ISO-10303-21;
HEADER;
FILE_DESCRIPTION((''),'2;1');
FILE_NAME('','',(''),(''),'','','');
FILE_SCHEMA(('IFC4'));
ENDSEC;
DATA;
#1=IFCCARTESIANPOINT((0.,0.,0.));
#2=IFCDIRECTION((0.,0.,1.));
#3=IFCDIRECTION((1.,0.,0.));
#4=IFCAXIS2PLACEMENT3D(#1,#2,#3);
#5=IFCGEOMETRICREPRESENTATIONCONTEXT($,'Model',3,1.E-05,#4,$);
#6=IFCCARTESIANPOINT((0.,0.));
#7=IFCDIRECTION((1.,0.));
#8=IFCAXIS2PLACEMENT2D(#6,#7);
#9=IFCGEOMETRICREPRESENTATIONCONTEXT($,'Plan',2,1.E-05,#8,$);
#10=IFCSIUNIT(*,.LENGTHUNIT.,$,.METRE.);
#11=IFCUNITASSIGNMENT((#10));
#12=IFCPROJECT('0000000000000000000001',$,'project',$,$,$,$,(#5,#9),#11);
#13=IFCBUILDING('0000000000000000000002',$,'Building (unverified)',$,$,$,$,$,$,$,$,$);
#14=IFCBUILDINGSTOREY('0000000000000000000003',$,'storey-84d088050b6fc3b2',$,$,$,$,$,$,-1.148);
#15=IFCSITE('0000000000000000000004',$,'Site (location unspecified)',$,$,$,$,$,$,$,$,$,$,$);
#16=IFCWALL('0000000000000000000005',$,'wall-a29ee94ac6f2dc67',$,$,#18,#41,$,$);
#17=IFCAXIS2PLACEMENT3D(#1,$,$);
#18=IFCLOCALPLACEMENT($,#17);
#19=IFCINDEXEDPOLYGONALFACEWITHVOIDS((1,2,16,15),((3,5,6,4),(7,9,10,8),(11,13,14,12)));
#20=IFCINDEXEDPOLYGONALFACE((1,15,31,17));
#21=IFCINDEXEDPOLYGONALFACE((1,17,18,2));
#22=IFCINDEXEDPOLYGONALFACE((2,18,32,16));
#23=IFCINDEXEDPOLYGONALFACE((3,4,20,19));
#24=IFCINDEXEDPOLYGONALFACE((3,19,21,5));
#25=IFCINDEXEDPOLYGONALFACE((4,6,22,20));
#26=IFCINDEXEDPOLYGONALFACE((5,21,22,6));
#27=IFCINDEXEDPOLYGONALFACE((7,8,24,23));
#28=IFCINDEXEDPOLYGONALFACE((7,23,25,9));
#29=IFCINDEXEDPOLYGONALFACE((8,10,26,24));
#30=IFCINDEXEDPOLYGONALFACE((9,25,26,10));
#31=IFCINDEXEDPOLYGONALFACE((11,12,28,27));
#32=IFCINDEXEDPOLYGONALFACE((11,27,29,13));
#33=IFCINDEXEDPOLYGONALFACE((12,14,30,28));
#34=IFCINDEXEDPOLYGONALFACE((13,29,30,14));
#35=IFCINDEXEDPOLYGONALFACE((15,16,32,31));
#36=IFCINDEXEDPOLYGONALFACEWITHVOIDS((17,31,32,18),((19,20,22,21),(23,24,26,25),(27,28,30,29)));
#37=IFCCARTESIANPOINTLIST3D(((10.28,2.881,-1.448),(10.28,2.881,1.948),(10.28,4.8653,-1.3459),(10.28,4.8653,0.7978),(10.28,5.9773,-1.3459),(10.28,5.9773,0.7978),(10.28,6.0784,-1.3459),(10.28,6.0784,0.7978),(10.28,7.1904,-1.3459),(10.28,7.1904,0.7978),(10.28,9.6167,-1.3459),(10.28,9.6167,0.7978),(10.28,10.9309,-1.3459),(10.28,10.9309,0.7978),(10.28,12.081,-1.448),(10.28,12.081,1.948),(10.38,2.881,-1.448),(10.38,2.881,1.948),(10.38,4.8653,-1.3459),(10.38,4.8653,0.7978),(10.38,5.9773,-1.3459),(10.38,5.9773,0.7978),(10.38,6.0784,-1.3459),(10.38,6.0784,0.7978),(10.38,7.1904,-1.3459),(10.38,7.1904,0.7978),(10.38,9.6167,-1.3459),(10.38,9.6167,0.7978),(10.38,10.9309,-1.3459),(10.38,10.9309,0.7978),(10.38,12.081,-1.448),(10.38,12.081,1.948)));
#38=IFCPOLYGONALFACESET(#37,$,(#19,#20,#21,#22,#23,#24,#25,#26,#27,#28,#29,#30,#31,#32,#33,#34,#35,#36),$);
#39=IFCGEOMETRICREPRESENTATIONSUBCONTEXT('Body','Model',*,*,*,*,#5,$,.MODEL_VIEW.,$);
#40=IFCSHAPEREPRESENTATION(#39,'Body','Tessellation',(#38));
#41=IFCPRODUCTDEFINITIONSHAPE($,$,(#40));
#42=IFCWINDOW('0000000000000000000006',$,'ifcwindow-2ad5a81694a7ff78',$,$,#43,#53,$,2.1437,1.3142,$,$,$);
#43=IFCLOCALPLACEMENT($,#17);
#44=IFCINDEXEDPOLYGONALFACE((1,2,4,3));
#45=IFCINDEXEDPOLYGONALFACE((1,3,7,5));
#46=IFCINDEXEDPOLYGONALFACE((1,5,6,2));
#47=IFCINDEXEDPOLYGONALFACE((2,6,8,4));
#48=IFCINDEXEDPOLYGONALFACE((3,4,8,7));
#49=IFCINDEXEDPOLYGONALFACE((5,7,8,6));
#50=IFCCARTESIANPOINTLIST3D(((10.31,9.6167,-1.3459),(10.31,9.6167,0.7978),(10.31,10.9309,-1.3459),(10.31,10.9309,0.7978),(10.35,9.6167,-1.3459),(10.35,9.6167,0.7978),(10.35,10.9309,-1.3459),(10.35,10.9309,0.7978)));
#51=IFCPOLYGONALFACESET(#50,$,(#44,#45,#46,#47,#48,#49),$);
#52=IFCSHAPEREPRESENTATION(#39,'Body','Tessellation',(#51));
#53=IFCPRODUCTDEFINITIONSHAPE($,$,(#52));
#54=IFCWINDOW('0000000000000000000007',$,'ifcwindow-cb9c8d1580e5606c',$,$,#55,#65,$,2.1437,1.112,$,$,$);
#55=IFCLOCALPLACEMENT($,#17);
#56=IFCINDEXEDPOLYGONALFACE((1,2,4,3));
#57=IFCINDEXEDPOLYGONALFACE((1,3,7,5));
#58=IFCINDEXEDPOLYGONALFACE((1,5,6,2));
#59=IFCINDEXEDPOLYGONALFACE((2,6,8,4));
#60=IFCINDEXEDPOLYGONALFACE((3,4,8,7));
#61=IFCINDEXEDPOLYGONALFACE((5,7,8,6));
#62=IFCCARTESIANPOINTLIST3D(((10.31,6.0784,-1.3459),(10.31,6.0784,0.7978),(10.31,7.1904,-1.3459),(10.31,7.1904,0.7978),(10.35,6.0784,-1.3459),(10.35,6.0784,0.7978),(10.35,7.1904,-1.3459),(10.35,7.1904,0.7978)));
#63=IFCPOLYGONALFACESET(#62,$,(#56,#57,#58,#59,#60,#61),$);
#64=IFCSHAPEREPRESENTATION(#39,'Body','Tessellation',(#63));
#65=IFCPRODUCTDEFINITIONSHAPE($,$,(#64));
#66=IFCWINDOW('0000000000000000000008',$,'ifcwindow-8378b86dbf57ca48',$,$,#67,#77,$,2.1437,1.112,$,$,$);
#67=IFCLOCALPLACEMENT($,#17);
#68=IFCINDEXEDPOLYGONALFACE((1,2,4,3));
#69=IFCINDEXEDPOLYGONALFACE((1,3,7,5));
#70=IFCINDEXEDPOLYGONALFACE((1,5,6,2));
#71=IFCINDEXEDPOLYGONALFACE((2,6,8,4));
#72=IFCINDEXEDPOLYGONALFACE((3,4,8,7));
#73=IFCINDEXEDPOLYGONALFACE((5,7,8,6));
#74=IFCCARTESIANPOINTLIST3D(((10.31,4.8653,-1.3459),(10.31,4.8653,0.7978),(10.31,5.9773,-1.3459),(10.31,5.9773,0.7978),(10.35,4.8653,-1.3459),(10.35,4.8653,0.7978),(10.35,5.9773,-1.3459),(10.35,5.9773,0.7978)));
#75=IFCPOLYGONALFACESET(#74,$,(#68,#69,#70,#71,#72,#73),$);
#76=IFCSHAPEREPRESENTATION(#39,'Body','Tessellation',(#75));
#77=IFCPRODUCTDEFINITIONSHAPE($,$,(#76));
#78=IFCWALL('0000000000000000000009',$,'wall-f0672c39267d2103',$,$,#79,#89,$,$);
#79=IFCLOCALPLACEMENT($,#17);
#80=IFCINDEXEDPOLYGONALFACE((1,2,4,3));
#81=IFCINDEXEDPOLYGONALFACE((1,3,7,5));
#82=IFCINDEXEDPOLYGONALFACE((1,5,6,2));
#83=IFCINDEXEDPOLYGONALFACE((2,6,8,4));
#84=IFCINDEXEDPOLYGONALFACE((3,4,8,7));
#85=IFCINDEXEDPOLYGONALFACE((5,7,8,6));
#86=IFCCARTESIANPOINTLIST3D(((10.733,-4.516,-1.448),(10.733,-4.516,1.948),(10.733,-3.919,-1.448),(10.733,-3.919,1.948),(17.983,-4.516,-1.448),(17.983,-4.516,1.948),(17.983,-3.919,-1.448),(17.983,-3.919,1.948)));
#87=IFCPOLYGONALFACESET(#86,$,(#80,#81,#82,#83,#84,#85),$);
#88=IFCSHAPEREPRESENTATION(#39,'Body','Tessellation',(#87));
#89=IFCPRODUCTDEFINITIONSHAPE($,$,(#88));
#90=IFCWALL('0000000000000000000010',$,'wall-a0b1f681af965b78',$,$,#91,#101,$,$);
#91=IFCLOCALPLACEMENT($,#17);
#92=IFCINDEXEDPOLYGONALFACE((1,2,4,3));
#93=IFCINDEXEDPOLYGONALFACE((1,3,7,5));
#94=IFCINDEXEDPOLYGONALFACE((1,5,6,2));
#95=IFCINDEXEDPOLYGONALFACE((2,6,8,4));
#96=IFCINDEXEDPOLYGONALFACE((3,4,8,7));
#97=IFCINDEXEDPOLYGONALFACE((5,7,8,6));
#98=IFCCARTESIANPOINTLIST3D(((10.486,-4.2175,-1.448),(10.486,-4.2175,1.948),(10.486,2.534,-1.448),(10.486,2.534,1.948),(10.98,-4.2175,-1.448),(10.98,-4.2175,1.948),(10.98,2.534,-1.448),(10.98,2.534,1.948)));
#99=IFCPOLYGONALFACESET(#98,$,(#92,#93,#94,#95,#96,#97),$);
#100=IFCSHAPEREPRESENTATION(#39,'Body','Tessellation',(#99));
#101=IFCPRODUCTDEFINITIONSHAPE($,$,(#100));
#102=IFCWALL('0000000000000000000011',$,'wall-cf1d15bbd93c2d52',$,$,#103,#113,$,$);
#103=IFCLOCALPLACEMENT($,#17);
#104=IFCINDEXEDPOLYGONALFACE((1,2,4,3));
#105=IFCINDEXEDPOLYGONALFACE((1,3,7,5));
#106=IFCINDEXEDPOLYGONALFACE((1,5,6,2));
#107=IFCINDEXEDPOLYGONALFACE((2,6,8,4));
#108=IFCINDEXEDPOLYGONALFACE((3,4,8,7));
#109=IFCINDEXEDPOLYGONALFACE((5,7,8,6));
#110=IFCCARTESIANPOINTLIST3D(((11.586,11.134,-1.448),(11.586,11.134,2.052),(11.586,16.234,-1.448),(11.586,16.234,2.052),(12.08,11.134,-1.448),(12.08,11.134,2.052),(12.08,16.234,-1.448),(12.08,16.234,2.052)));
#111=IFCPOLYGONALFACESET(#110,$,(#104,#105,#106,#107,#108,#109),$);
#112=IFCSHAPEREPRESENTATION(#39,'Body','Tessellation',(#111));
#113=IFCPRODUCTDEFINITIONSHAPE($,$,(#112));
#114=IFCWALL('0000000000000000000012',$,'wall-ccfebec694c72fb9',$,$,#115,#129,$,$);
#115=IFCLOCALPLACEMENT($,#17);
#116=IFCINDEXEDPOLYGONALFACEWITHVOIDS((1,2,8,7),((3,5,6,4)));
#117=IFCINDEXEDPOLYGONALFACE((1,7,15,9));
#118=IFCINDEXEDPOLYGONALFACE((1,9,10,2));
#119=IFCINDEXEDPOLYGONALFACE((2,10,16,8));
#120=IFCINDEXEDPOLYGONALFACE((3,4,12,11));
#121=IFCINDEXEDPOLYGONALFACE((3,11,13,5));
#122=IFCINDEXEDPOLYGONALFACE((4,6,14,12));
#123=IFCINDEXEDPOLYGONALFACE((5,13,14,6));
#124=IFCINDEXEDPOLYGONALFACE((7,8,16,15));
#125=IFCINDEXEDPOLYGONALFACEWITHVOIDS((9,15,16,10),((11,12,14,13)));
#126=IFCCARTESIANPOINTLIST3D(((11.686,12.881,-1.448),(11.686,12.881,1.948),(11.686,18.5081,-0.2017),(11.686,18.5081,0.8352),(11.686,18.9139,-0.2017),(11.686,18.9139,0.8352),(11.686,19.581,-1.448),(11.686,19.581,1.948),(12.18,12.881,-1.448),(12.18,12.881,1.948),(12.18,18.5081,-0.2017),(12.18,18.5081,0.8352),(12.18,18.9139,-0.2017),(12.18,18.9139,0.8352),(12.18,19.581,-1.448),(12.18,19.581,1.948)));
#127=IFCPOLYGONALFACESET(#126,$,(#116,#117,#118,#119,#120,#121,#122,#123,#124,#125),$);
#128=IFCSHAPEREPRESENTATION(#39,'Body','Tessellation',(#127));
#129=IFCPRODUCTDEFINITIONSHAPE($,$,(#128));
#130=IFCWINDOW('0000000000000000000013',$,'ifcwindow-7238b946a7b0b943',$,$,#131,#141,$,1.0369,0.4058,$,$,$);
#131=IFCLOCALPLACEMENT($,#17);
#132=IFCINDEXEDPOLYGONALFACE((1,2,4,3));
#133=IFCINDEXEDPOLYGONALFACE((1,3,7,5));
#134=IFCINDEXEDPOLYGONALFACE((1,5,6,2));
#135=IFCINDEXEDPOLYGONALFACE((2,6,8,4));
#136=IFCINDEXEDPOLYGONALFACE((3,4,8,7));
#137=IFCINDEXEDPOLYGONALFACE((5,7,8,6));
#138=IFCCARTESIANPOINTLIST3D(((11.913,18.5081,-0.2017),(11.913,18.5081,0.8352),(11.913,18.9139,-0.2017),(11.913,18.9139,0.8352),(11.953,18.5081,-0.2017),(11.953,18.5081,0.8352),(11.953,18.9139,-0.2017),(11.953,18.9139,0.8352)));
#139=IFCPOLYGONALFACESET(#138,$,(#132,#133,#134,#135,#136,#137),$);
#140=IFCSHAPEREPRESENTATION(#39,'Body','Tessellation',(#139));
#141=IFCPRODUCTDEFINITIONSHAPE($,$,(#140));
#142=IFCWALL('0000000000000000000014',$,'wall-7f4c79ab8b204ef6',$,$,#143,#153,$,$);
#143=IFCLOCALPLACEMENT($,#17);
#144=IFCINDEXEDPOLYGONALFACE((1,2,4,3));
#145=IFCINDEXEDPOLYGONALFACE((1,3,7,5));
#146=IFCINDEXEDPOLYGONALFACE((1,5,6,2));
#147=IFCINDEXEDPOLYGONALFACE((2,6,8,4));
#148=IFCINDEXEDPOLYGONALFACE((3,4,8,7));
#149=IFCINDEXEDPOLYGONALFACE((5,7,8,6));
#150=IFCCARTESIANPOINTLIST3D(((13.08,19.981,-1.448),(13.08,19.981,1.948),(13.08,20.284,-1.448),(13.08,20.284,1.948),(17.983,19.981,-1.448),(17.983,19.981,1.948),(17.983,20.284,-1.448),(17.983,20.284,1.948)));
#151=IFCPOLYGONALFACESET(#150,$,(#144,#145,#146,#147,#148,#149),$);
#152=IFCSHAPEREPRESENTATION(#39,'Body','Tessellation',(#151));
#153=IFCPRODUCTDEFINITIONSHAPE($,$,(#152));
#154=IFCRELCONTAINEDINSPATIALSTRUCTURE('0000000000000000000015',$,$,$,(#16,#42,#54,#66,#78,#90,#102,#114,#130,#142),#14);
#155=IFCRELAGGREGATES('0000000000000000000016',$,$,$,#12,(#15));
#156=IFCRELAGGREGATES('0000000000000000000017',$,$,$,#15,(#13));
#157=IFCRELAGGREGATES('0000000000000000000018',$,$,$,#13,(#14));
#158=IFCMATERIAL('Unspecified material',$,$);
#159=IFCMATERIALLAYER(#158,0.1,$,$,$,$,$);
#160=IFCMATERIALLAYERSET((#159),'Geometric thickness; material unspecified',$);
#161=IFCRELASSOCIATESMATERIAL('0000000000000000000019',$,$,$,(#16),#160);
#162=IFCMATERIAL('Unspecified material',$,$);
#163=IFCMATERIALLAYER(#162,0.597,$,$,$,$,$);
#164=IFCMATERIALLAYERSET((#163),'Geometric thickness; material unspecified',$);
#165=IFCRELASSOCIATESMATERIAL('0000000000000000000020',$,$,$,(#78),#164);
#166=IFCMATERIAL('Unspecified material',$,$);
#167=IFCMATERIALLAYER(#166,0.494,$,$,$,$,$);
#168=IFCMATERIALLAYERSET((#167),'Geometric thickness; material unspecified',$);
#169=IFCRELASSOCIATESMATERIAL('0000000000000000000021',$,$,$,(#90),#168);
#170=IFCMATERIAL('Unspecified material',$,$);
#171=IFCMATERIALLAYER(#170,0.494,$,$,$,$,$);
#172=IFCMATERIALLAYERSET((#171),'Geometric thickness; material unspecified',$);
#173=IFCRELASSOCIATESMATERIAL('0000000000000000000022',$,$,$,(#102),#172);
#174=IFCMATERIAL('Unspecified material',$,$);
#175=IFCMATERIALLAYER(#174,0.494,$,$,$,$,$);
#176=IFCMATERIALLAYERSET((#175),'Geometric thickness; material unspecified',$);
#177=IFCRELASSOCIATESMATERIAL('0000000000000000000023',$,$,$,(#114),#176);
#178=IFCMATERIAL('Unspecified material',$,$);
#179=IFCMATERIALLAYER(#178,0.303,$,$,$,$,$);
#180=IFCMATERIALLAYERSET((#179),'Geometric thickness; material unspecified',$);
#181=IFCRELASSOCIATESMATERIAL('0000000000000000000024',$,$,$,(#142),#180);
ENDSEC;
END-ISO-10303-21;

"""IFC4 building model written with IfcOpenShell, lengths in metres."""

from ifc_helpers import new_model, si_unit, frame, origin_with_axes, origin_2d_with_axis, place, context, subcontext, project, spatial, line, indexed_curve, outline, extrude, material, layer, layer_set, layer_usage, element, fill, save


model = new_model("IFC4")

# Units and contexts
model_context = context("Model", 3, precision=1e-05, world=origin_with_axes())
plan_context = context("Plan", 2, precision=1e-05, world=origin_2d_with_axis())
body_context = subcontext(model_context, "Body", "Model", "MODEL_VIEW")
ifc_project = project(units=[si_unit("LENGTHUNIT", "METRE")], contexts=[model_context, plan_context])

# Site, building, storey
site = spatial("IfcSite", under=ifc_project, Name="Site (location unspecified)")
building = spatial("IfcBuilding", under=site, Name="Building (unverified)")
storey = spatial("IfcBuildingStorey", under=building, Name="storey-84d088050b6fc3b2", Elevation=-1.148)

# Wall, openings, windows
ifc_material_1 = material(Name="Unspecified material")
ifc_layer_1 = layer(ifc_material_1, 0.1)
ifc_layer_set_1 = layer_set([ifc_layer_1], Name="Geometric thickness; material unspecified")
ifc_layer_usage_1 = layer_usage(ifc_layer_set_1, "AXIS2", "POSITIVE", -0.05)
wall_1_placement = place(None, frame((10.33, 12.081, -1.448), z_axis=(0.0, 0.0, 1.0), x_axis=(0.0, -1.0, 0.0)))
wall_1 = element("IfcWall", 1, at=wall_1_placement, inside=storey, material=ifc_layer_usage_1, Name="wall-a29ee94ac6f2dc67", context=body_context, shape_type="SweptSolid", body=[
    extrude(outline(indexed_curve([(0.0, 0.0), (0.0, 0.1), (9.2, 0.1), (9.2, 0.0), (0.0, 0.0)], self_intersect=False)), frame((0.0, -0.05, 0.0), z_axis=(0.0, 0.0, 1.0), x_axis=(1.0, 0.0, 0.0)), (0.0, 0.0, 1.0), 3.396),
])
opening_1_placement = place(wall_1_placement, frame((1.1501, -0.06, 0.1021), z_axis=(0.0, 0.0, 1.0), x_axis=(1.0, 0.0, 0.0)))
opening_1 = element("IfcOpeningElement", 2, at=opening_1_placement, cuts=wall_1, context=body_context, shape_type="SweptSolid", body=[
    extrude(outline(indexed_curve([(0.0, 0.0), (0.0, 0.12), (1.3142, 0.12), (1.3142, 0.0), (0.0, 0.0)], self_intersect=False)), origin_with_axes(), (0.0, 0.0, 1.0), 2.1437),
])
opening_2_placement = place(wall_1_placement, frame((4.8906, -0.06, 0.1021), z_axis=(0.0, 0.0, 1.0), x_axis=(1.0, 0.0, 0.0)))
opening_2 = element("IfcOpeningElement", 3, at=opening_2_placement, cuts=wall_1, context=body_context, shape_type="SweptSolid", body=[
    extrude(outline(indexed_curve([(0.0, 0.0), (0.0, 0.12), (1.112, 0.12), (1.112, 0.0), (0.0, 0.0)], self_intersect=False)), origin_with_axes(), (0.0, 0.0, 1.0), 2.1437),
])
opening_3_placement = place(wall_1_placement, frame((6.1037, -0.06, 0.1021), z_axis=(0.0, 0.0, 1.0), x_axis=(1.0, 0.0, 0.0)))
opening_3 = element("IfcOpeningElement", 4, at=opening_3_placement, cuts=wall_1, context=body_context, shape_type="SweptSolid", body=[
    extrude(outline(indexed_curve([(0.0, 0.0), (0.0, 0.12), (1.112, 0.12), (1.112, 0.0), (0.0, 0.0)], self_intersect=False)), origin_with_axes(), (0.0, 0.0, 1.0), 2.1437),
])
window_1_placement = place(None, frame((10.31, 10.9309, -1.3459), z_axis=(0.0, 0.0, 1.0), x_axis=(0.0, -1.0, 0.0)))
window_1 = element("IfcWindow", 5, at=window_1_placement, inside=storey, Name="ifcwindow-2ad5a81694a7ff78", OverallHeight=2.1437, OverallWidth=1.3142, context=body_context, shape_type="SweptSolid", body=[
    extrude(outline(indexed_curve([(0.0, 0.0), (0.0, 0.04), (1.3142, 0.04), (1.3142, 0.0), (0.0, 0.0)], self_intersect=False)), origin_with_axes(), (0.0, 0.0, 1.0), 2.1437),
])
fill(opening_1, window_1)
window_2_placement = place(None, frame((10.31, 7.1904, -1.3459), z_axis=(0.0, 0.0, 1.0), x_axis=(0.0, -1.0, 0.0)))
window_2 = element("IfcWindow", 6, at=window_2_placement, inside=storey, Name="ifcwindow-cb9c8d1580e5606c", OverallHeight=2.1437, OverallWidth=1.112, context=body_context, shape_type="SweptSolid", body=[
    extrude(outline(indexed_curve([(0.0, 0.0), (0.0, 0.04), (1.112, 0.04), (1.112, 0.0), (0.0, 0.0)], self_intersect=False)), origin_with_axes(), (0.0, 0.0, 1.0), 2.1437),
])
fill(opening_2, window_2)
window_3_placement = place(None, frame((10.31, 5.9773, -1.3459), z_axis=(0.0, 0.0, 1.0), x_axis=(0.0, -1.0, 0.0)))
window_3 = element("IfcWindow", 7, at=window_3_placement, inside=storey, Name="ifcwindow-8378b86dbf57ca48", OverallHeight=2.1437, OverallWidth=1.112, context=body_context, shape_type="SweptSolid", body=[
    extrude(outline(indexed_curve([(0.0, 0.0), (0.0, 0.04), (1.112, 0.04), (1.112, 0.0), (0.0, 0.0)], self_intersect=False)), origin_with_axes(), (0.0, 0.0, 1.0), 2.1437),
])
fill(opening_3, window_3)

# Walls
ifc_material_2 = material(Name="Unspecified material")
ifc_layer_2 = layer(ifc_material_2, 0.597)
ifc_layer_set_2 = layer_set([ifc_layer_2], Name="Geometric thickness; material unspecified")
ifc_layer_usage_2 = layer_usage(ifc_layer_set_2, "AXIS2", "POSITIVE", -0.2985)
wall_2_placement = place(None, frame((17.983, -4.2175, -1.448), z_axis=(0.0, 0.0, 1.0), x_axis=(-1.0, 0.0, 0.0)))
element("IfcWall", 8, at=wall_2_placement, inside=storey, material=ifc_layer_usage_2, Name="wall-f0672c39267d2103", context=body_context, shape_type="SweptSolid", body=[
    extrude(outline(indexed_curve([(0.0, 0.0), (0.0, 0.597), (7.25, 0.597), (7.25, 0.0), (0.0, 0.0)], self_intersect=False)), frame((0.0, -0.2985, 0.0), z_axis=(0.0, 0.0, 1.0), x_axis=(1.0, 0.0, 0.0)), (0.0, 0.0, 1.0), 3.396),
])
ifc_material_3 = material(Name="Unspecified material")
ifc_layer_3 = layer(ifc_material_3, 0.494)
ifc_layer_set_3 = layer_set([ifc_layer_3], Name="Geometric thickness; material unspecified")
ifc_layer_usage_3 = layer_usage(ifc_layer_set_3, "AXIS2", "POSITIVE", -0.247)
wall_3_placement = place(None, frame((10.733, -4.2175, -1.448), z_axis=(0.0, 0.0, 1.0), x_axis=(0.0, 1.0, 0.0)))
element("IfcWall", 9, at=wall_3_placement, inside=storey, material=ifc_layer_usage_3, Name="wall-a0b1f681af965b78", context=body_context, shape_type="SweptSolid", body=[
    extrude(outline(indexed_curve([(0.0, 0.0), (0.0, 0.494), (6.7515, 0.494), (6.7515, 0.0), (0.0, 0.0)], self_intersect=False)), frame((0.0, -0.247, 0.0), z_axis=(0.0, 0.0, 1.0), x_axis=(1.0, 0.0, 0.0)), (0.0, 0.0, 1.0), 3.396),
])
ifc_material_4 = material(Name="Unspecified material")
ifc_layer_4 = layer(ifc_material_4, 0.494)
ifc_layer_set_4 = layer_set([ifc_layer_4], Name="Geometric thickness; material unspecified")
ifc_layer_usage_4 = layer_usage(ifc_layer_set_4, "AXIS2", "POSITIVE", -0.247)
wall_4_placement = place(None, frame((11.833, 11.134, -1.448), z_axis=(0.0, 0.0, 1.0), x_axis=(0.0, 1.0, 0.0)))
element("IfcWall", 10, at=wall_4_placement, inside=storey, material=ifc_layer_usage_4, Name="wall-cf1d15bbd93c2d52", context=body_context, shape_type="SweptSolid", body=[
    extrude(outline(indexed_curve([(0.0, -0.247), (0.0, 0.247), (5.1, 0.247), (5.1, -0.247)], segments=[line(1, 2, 3, 4, 1)])), origin_with_axes(), (0.0, 0.0, 1.0), 3.5),
])

# Wall, opening, window
ifc_material_5 = material(Name="Unspecified material")
ifc_layer_5 = layer(ifc_material_5, 0.494)
ifc_layer_set_5 = layer_set([ifc_layer_5], Name="Geometric thickness; material unspecified")
ifc_layer_usage_5 = layer_usage(ifc_layer_set_5, "AXIS2", "POSITIVE", -0.247)
wall_5_placement = place(None, frame((11.933, 12.881, -1.448), z_axis=(0.0, 0.0, 1.0), x_axis=(0.0, 1.0, 0.0)))
wall_5 = element("IfcWall", 11, at=wall_5_placement, inside=storey, material=ifc_layer_usage_5, Name="wall-ccfebec694c72fb9", context=body_context, shape_type="SweptSolid", body=[
    extrude(outline(indexed_curve([(0.0, 0.0), (0.0, 0.494), (6.7, 0.494), (6.7, 0.0), (0.0, 0.0)], self_intersect=False)), frame((0.0, -0.247, 0.0), z_axis=(0.0, 0.0, 1.0), x_axis=(1.0, 0.0, 0.0)), (0.0, 0.0, 1.0), 3.396),
])
opening_4_placement = place(wall_5_placement, frame((5.6271, -0.257, 1.2463), z_axis=(0.0, 0.0, 1.0), x_axis=(1.0, 0.0, 0.0)))
opening_4 = element("IfcOpeningElement", 12, at=opening_4_placement, cuts=wall_5, context=body_context, shape_type="SweptSolid", body=[
    extrude(outline(indexed_curve([(0.0, 0.0), (0.0, 0.514), (0.4058, 0.514), (0.4058, 0.0), (0.0, 0.0)], self_intersect=False)), origin_with_axes(), (0.0, 0.0, 1.0), 1.0369),
])
window_4_placement = place(None, frame((11.953, 18.5081, -0.2017), z_axis=(0.0, 0.0, 1.0), x_axis=(0.0, 1.0, 0.0)))
window_4 = element("IfcWindow", 13, at=window_4_placement, inside=storey, Name="ifcwindow-7238b946a7b0b943", OverallHeight=1.0369, OverallWidth=0.4058, context=body_context, shape_type="SweptSolid", body=[
    extrude(outline(indexed_curve([(0.0, 0.0), (0.0, 0.04), (0.4058, 0.04), (0.4058, 0.0), (0.0, 0.0)], self_intersect=False)), origin_with_axes(), (0.0, 0.0, 1.0), 1.0369),
])
fill(opening_4, window_4)

# Wall
ifc_material_6 = material(Name="Unspecified material")
ifc_layer_6 = layer(ifc_material_6, 0.303)
ifc_layer_set_6 = layer_set([ifc_layer_6], Name="Geometric thickness; material unspecified")
ifc_layer_usage_6 = layer_usage(ifc_layer_set_6, "AXIS2", "POSITIVE", -0.1515)
wall_6_placement = place(None, frame((13.08, 20.1325, -1.448), z_axis=(0.0, 0.0, 1.0), x_axis=(1.0, 0.0, 0.0)))
element("IfcWall", 14, at=wall_6_placement, inside=storey, material=ifc_layer_usage_6, Name="wall-7f4c79ab8b204ef6", context=body_context, shape_type="SweptSolid", body=[
    extrude(outline(indexed_curve([(0.0, 0.0), (0.0, 0.303), (4.903, 0.303), (4.903, 0.0), (0.0, 0.0)], self_intersect=False)), frame((0.0, -0.1515, 0.0), z_axis=(0.0, 0.0, 1.0), x_axis=(1.0, 0.0, 0.0)), (0.0, 0.0, 1.0), 3.396),
])

save(model, "model.ifc")
